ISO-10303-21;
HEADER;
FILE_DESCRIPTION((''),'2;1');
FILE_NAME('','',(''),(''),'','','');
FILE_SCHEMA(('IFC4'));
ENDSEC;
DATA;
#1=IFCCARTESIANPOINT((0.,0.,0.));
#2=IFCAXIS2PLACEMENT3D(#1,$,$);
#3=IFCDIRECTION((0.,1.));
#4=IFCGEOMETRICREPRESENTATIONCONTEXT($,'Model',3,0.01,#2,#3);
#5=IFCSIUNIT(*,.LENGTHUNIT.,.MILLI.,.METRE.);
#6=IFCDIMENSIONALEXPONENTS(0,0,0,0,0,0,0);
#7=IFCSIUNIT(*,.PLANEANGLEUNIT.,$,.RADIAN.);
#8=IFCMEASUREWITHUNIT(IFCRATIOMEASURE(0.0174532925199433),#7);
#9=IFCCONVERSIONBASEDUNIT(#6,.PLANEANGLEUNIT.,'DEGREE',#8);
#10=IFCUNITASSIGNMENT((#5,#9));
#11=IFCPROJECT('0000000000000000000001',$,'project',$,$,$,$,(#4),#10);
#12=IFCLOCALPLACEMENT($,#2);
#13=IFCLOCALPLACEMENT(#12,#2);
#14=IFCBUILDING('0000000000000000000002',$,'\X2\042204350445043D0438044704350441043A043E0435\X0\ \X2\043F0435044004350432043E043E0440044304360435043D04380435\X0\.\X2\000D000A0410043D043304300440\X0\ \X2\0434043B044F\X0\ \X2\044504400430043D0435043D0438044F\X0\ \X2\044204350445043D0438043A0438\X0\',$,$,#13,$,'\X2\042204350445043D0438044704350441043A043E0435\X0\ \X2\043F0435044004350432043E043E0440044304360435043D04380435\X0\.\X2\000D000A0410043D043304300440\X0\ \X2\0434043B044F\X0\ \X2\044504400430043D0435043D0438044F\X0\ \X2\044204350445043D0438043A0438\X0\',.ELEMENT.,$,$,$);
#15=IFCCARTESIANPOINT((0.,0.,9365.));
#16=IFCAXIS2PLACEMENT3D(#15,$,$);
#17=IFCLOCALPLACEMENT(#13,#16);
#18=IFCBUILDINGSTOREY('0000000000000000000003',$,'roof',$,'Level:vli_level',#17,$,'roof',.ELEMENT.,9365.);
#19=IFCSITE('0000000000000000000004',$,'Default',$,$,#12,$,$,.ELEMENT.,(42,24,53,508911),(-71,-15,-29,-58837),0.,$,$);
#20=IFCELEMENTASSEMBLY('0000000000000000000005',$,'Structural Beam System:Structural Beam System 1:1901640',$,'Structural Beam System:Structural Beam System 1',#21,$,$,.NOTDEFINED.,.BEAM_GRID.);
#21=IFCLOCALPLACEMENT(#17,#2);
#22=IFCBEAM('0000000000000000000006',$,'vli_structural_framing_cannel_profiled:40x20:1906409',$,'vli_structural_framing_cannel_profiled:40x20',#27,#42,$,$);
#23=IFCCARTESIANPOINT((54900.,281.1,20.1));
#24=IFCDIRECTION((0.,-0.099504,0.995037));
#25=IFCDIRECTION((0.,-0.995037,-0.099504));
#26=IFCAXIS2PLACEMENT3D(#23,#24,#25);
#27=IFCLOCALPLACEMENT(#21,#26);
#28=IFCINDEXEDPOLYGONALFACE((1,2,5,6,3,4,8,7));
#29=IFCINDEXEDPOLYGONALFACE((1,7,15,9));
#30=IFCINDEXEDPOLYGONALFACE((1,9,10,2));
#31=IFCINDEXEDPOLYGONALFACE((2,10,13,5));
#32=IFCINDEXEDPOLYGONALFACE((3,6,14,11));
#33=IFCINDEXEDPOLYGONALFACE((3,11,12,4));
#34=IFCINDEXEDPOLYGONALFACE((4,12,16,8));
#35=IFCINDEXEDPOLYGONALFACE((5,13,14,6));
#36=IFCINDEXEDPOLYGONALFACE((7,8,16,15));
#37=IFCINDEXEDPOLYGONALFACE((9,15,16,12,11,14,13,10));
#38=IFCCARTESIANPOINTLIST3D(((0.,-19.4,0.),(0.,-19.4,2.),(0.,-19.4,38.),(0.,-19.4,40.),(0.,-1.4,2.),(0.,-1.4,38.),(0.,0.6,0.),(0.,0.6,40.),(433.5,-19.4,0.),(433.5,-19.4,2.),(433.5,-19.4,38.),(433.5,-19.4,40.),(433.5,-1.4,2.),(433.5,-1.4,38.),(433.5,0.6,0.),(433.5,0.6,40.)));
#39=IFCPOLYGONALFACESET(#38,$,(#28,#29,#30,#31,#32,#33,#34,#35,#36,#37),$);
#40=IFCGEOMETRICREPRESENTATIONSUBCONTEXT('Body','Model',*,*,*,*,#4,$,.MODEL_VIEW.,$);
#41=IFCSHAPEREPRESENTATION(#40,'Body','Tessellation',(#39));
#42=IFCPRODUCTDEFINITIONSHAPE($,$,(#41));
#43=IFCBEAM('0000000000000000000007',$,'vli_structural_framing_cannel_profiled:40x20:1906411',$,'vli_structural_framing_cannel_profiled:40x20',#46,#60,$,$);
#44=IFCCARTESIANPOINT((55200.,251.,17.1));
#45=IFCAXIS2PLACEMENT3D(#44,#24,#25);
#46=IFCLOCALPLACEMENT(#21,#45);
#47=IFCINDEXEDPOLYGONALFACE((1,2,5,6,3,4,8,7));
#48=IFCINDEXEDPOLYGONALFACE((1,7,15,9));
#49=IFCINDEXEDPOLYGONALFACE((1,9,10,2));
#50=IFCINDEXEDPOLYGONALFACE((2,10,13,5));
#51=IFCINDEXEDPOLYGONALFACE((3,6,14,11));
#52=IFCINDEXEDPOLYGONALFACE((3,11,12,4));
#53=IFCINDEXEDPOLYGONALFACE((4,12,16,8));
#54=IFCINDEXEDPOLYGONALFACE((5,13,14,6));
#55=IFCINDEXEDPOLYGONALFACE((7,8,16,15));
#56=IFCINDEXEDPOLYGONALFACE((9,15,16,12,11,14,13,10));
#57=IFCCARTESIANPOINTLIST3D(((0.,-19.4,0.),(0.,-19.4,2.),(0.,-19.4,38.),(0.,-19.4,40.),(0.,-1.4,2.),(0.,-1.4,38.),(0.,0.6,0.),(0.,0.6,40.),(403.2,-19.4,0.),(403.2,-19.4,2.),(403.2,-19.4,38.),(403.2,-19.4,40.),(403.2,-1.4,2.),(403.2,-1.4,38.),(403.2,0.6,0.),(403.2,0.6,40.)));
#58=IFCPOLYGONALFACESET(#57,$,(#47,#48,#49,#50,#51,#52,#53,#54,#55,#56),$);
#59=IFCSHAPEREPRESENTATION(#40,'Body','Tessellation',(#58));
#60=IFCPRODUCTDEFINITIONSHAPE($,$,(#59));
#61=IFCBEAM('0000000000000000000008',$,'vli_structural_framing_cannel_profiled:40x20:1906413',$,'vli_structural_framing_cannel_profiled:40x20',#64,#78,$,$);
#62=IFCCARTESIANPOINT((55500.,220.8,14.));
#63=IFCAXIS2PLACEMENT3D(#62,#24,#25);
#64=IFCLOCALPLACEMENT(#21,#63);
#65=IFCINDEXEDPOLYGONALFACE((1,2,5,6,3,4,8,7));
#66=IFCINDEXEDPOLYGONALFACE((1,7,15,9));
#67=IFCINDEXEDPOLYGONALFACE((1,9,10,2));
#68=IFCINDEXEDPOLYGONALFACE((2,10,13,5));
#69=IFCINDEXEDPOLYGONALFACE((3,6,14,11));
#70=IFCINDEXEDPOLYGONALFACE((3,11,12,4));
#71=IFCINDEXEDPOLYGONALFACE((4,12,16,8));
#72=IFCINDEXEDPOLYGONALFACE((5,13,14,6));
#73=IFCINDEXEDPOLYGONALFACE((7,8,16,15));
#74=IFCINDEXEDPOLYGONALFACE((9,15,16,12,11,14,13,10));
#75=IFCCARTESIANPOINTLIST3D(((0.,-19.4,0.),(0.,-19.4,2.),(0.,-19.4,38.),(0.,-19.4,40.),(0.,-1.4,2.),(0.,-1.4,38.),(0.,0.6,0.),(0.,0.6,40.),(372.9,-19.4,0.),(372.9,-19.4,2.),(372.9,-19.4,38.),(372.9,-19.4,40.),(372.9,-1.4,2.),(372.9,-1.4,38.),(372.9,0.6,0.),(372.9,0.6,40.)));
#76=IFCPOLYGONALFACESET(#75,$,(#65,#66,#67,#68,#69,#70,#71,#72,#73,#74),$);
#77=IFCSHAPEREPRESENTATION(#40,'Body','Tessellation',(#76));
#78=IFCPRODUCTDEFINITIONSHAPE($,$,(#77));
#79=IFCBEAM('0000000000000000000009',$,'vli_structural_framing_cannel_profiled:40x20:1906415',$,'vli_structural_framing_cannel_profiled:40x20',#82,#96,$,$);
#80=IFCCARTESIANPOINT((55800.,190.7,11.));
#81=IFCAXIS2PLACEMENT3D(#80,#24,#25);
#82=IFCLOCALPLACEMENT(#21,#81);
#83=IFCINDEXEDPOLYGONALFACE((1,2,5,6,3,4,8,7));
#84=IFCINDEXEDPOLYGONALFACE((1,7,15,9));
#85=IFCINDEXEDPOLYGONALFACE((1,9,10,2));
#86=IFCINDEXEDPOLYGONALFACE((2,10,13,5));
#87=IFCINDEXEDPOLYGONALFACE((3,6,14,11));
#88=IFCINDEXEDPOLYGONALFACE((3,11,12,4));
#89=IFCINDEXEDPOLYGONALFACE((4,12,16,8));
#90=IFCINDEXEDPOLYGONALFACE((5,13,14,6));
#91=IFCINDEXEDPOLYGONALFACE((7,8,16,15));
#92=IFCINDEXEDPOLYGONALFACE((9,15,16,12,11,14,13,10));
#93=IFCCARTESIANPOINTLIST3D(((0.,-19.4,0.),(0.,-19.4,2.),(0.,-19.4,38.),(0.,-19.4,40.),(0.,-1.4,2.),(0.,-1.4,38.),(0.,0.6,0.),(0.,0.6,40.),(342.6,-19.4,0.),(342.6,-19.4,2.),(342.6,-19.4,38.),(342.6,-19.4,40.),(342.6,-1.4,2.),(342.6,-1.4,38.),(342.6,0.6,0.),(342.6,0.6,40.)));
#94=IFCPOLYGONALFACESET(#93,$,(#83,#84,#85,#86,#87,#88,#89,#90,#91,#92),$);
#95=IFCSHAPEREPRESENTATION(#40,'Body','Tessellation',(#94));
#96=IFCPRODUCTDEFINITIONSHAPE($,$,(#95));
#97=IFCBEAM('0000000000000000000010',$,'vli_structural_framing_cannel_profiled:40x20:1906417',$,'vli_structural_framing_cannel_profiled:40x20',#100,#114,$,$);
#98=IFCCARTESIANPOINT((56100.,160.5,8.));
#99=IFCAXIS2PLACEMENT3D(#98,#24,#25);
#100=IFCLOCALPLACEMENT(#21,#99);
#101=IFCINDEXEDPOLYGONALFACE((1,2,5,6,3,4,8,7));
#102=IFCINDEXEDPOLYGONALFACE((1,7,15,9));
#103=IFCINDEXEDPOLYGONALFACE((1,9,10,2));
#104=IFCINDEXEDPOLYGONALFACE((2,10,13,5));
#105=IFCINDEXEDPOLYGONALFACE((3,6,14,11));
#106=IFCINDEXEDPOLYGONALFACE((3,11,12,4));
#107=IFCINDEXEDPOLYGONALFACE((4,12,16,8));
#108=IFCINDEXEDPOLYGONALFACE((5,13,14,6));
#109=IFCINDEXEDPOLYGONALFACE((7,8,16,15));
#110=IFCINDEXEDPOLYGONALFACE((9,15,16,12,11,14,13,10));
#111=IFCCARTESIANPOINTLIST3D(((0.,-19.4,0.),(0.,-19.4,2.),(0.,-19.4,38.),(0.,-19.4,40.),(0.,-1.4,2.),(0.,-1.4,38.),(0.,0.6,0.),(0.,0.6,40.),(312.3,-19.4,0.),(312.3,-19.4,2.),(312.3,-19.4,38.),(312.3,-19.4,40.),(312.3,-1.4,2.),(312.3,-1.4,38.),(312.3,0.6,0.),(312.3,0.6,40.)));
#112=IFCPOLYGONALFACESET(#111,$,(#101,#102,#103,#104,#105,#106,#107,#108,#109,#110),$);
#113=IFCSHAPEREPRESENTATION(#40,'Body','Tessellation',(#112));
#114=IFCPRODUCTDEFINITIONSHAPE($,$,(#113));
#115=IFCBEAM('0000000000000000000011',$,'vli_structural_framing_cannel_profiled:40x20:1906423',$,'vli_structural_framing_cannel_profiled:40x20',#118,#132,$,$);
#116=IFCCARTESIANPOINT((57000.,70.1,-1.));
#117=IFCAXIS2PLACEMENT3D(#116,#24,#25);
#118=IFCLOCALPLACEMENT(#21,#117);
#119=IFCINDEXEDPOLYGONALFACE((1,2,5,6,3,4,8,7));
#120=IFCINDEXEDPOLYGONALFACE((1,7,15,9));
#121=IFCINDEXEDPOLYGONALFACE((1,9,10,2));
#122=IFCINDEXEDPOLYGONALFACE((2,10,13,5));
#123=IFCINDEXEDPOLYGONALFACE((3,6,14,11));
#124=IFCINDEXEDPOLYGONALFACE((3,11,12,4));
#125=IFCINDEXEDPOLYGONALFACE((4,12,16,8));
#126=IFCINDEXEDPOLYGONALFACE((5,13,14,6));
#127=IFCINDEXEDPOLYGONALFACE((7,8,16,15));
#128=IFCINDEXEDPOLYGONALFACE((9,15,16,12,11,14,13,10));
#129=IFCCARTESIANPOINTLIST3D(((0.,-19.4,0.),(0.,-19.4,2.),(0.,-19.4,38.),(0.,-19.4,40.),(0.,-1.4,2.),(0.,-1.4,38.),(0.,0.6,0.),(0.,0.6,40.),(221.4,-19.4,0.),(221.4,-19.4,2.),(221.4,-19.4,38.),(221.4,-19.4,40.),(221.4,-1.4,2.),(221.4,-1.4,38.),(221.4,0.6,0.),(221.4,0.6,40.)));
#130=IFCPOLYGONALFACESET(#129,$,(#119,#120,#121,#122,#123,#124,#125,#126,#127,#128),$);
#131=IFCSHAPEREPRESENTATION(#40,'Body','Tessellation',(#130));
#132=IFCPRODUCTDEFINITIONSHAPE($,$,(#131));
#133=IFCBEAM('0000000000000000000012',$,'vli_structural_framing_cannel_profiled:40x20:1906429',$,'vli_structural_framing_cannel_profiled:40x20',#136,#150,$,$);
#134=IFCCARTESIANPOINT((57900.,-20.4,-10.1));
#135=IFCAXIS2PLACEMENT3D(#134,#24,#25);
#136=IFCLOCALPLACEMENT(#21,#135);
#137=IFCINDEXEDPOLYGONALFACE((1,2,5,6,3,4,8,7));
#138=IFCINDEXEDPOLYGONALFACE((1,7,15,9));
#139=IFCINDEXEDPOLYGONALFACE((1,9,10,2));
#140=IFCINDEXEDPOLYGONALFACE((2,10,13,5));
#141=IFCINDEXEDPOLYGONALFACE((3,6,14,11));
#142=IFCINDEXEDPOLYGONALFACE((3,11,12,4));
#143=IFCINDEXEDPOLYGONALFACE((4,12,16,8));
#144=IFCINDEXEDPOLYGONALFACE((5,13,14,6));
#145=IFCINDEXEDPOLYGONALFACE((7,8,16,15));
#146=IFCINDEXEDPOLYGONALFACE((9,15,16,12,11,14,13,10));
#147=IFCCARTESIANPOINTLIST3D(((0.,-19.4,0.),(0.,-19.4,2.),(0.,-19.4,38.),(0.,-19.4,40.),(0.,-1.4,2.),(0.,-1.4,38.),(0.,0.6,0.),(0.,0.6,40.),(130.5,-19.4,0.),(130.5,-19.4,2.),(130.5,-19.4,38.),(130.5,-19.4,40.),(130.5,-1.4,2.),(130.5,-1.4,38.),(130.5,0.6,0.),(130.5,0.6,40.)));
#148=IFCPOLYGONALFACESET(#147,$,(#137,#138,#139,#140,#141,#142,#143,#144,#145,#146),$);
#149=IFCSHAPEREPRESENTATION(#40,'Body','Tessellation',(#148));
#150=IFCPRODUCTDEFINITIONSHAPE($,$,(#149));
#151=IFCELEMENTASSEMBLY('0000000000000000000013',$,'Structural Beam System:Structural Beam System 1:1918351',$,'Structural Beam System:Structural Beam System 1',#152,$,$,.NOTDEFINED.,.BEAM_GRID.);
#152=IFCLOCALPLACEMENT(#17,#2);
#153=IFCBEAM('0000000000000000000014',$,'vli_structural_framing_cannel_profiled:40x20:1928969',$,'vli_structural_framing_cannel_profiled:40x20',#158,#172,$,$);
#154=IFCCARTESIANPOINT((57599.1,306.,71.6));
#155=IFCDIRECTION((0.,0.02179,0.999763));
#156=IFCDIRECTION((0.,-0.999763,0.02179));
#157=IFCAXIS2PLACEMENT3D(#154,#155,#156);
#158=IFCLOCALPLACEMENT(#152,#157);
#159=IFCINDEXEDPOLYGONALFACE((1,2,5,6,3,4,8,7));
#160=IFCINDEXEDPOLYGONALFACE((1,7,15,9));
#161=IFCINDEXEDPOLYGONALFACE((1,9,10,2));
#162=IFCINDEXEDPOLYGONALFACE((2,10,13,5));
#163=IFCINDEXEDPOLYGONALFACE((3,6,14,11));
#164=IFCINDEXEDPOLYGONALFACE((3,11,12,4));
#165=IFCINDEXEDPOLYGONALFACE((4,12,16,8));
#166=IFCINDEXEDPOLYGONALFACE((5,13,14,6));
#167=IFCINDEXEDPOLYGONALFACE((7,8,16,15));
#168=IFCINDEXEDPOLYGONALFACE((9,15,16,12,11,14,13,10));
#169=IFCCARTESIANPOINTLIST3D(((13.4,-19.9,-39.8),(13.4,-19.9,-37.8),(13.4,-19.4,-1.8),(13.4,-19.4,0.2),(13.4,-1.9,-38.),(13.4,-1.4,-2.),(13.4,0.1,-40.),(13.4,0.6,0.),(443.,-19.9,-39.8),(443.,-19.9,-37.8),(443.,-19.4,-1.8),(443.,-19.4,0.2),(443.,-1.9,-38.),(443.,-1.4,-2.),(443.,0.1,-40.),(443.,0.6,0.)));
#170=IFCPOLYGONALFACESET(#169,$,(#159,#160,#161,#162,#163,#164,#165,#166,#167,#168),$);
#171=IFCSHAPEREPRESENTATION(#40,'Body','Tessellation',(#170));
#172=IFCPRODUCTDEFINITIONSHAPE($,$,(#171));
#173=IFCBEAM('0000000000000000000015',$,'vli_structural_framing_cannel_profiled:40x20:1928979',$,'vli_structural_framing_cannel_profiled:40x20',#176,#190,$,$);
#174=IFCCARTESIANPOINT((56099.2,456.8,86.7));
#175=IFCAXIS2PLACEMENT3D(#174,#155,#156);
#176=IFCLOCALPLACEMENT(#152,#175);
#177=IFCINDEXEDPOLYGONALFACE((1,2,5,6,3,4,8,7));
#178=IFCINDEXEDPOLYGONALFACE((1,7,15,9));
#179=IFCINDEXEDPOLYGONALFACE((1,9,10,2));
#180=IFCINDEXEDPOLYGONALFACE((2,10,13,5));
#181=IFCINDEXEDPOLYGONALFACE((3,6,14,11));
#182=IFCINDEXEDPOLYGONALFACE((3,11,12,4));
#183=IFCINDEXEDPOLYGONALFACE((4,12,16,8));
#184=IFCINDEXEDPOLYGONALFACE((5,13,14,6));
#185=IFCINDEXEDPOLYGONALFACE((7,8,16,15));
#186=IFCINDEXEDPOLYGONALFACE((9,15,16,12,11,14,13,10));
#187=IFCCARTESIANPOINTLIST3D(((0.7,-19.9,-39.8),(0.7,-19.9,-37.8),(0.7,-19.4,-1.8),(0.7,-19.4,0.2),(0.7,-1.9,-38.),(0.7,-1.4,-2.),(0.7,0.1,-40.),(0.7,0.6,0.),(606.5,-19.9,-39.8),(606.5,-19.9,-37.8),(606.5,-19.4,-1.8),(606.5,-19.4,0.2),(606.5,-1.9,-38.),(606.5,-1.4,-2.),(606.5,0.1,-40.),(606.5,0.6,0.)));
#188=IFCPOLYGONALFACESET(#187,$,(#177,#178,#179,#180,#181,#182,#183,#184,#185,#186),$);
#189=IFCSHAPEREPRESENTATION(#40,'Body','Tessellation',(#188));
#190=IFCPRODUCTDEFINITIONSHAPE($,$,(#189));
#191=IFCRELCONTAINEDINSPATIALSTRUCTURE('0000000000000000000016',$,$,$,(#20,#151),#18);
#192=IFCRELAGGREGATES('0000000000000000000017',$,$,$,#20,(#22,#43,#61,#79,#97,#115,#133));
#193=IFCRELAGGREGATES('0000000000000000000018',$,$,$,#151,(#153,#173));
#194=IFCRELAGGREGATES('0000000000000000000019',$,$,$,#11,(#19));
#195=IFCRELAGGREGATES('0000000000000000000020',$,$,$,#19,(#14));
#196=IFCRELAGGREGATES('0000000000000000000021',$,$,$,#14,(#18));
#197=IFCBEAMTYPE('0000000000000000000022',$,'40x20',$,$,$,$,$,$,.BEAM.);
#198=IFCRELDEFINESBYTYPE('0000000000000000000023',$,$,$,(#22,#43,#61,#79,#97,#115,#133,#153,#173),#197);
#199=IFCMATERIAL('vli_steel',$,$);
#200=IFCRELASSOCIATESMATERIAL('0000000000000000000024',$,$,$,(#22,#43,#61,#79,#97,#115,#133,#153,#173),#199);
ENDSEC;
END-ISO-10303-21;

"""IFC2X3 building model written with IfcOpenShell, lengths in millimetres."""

from ifc_helpers import new_model, entity, si_unit, converted_unit, direction, frame, origin, place, context, subcontext, project, spatial, polyline, outline, extrude, material, type_object, element, aggregate, save


model = new_model("IFC2X3")

# Units and contexts
model_context = context("Model", 3, precision=0.01, world=origin(), true_north=direction((0.0, 1.0)))
body_context = subcontext(model_context, "Body", "Model", "MODEL_VIEW")
ifc_project = project(units=[si_unit("LENGTHUNIT", "METRE", prefix="MILLI"), converted_unit("PLANEANGLEUNIT", "DEGREE", entity("IfcRatioMeasure", 0.0174532925199433), si_unit("PLANEANGLEUNIT", "RADIAN"), dimensions=[0, 0, 0, 0, 0, 0, 0])], contexts=[model_context])

# Site, building, storey
site_placement = place(None, origin())
site = spatial("IfcSite", under=ifc_project, at=site_placement, Name="Default", CompositionType="ELEMENT", RefLatitude=(42, 24, 53, 508911), RefLongitude=(-71, -15, -29, -58837), RefElevation=0.0)
building_placement = place(site_placement, origin())
building = spatial("IfcBuilding", under=site, at=building_placement, Name="Техническое перевооружение.\r\nАнгар для хранения техники", LongName="Техническое перевооружение.\r\nАнгар для хранения техники", CompositionType="ELEMENT")
storey_placement = place(building_placement, frame((0.0, 0.0, 9365.0)))
storey = spatial("IfcBuildingStorey", under=building, at=storey_placement, Name="roof", ObjectType="Level:vli_level", LongName="roof", CompositionType="ELEMENT", Elevation=9365.0)

# Element assemblies, beams
assembly_1_placement = place(storey_placement, origin())
assembly_1 = element("IfcElementAssembly", 1, at=assembly_1_placement, inside=storey, Name="Structural Beam System:Structural Beam System 1:1901640", ObjectType="Structural Beam System:Structural Beam System 1", AssemblyPlace="NOTDEFINED", PredefinedType="BEAM_GRID")
ifc_material = material(Name="vli_steel")
beam_type = type_object("IfcBeamType", Name="40x20", PredefinedType="BEAM")
beam_1_placement = place(assembly_1_placement, frame((54900.0, 281.1, 20.1), z_axis=(0.0, -0.099504, 0.995037), x_axis=(0.0, -0.995037, -0.099504)))
beam_1 = element("IfcBeam", 2, at=beam_1_placement, type_object=beam_type, material=ifc_material, Name="vli_structural_framing_cannel_profiled:40x20:1906409", ObjectType="vli_structural_framing_cannel_profiled:40x20", context=body_context, shape_type="SweptSolid", body=[
    extrude(outline(polyline([(-20.0, -9.5), (-18.0, -9.5), (-18.0, 8.5), (18.0, 8.5), (18.0, -9.5), (20.0, -9.5), (20.0, 10.5), (-20.0, 10.5), (-20.0, -9.5)])), frame((0.0, -9.9, 20.0), z_axis=(1.0, 0.0, 0.0), x_axis=(0.0, 0.0, -1.0)), (0.0, 0.0, 1.0), 433.5),
])
beam_2_placement = place(assembly_1_placement, frame((55200.0, 251.0, 17.1), z_axis=(0.0, -0.099504, 0.995037), x_axis=(0.0, -0.995037, -0.099504)))
beam_2 = element("IfcBeam", 3, at=beam_2_placement, type_object=beam_type, material=ifc_material, Name="vli_structural_framing_cannel_profiled:40x20:1906411", ObjectType="vli_structural_framing_cannel_profiled:40x20", context=body_context, shape_type="SweptSolid", body=[
    extrude(outline(polyline([(-20.0, -9.5), (-18.0, -9.5), (-18.0, 8.5), (18.0, 8.5), (18.0, -9.5), (20.0, -9.5), (20.0, 10.5), (-20.0, 10.5), (-20.0, -9.5)])), frame((0.0, -9.9, 20.0), z_axis=(1.0, 0.0, 0.0), x_axis=(0.0, 0.0, -1.0)), (0.0, 0.0, 1.0), 403.2),
])
beam_3_placement = place(assembly_1_placement, frame((55500.0, 220.8, 14.0), z_axis=(0.0, -0.099504, 0.995037), x_axis=(0.0, -0.995037, -0.099504)))
beam_3 = element("IfcBeam", 4, at=beam_3_placement, type_object=beam_type, material=ifc_material, Name="vli_structural_framing_cannel_profiled:40x20:1906413", ObjectType="vli_structural_framing_cannel_profiled:40x20", context=body_context, shape_type="SweptSolid", body=[
    extrude(outline(polyline([(-20.0, -9.5), (-18.0, -9.5), (-18.0, 8.5), (18.0, 8.5), (18.0, -9.5), (20.0, -9.5), (20.0, 10.5), (-20.0, 10.5), (-20.0, -9.5)])), frame((0.0, -9.9, 20.0), z_axis=(1.0, 0.0, 0.0), x_axis=(0.0, 0.0, -1.0)), (0.0, 0.0, 1.0), 372.9),
])
beam_4_placement = place(assembly_1_placement, frame((55800.0, 190.7, 11.0), z_axis=(0.0, -0.099504, 0.995037), x_axis=(0.0, -0.995037, -0.099504)))
beam_4 = element("IfcBeam", 5, at=beam_4_placement, type_object=beam_type, material=ifc_material, Name="vli_structural_framing_cannel_profiled:40x20:1906415", ObjectType="vli_structural_framing_cannel_profiled:40x20", context=body_context, shape_type="SweptSolid", body=[
    extrude(outline(polyline([(-20.0, -9.5), (-18.0, -9.5), (-18.0, 8.5), (18.0, 8.5), (18.0, -9.5), (20.0, -9.5), (20.0, 10.5), (-20.0, 10.5), (-20.0, -9.5)])), frame((0.0, -9.9, 20.0), z_axis=(1.0, 0.0, 0.0), x_axis=(0.0, 0.0, -1.0)), (0.0, 0.0, 1.0), 342.6),
])
beam_5_placement = place(assembly_1_placement, frame((56100.0, 160.5, 8.0), z_axis=(0.0, -0.099504, 0.995037), x_axis=(0.0, -0.995037, -0.099504)))
beam_5 = element("IfcBeam", 6, at=beam_5_placement, type_object=beam_type, material=ifc_material, Name="vli_structural_framing_cannel_profiled:40x20:1906417", ObjectType="vli_structural_framing_cannel_profiled:40x20", context=body_context, shape_type="SweptSolid", body=[
    extrude(outline(polyline([(-20.0, -9.5), (-18.0, -9.5), (-18.0, 8.5), (18.0, 8.5), (18.0, -9.5), (20.0, -9.5), (20.0, 10.5), (-20.0, 10.5), (-20.0, -9.5)])), frame((0.0, -9.9, 20.0), z_axis=(1.0, 0.0, 0.0), x_axis=(0.0, 0.0, -1.0)), (0.0, 0.0, 1.0), 312.3),
])
beam_6_placement = place(assembly_1_placement, frame((57000.0, 70.1, -1.0), z_axis=(0.0, -0.099504, 0.995037), x_axis=(0.0, -0.995037, -0.099504)))
beam_6 = element("IfcBeam", 7, at=beam_6_placement, type_object=beam_type, material=ifc_material, Name="vli_structural_framing_cannel_profiled:40x20:1906423", ObjectType="vli_structural_framing_cannel_profiled:40x20", context=body_context, shape_type="SweptSolid", body=[
    extrude(outline(polyline([(-20.0, -9.5), (-18.0, -9.5), (-18.0, 8.5), (18.0, 8.5), (18.0, -9.5), (20.0, -9.5), (20.0, 10.5), (-20.0, 10.5), (-20.0, -9.5)])), frame((0.0, -9.9, 20.0), z_axis=(1.0, 0.0, 0.0), x_axis=(0.0, 0.0, -1.0)), (0.0, 0.0, 1.0), 221.4),
])
beam_7_placement = place(assembly_1_placement, frame((57900.0, -20.4, -10.1), z_axis=(0.0, -0.099504, 0.995037), x_axis=(0.0, -0.995037, -0.099504)))
beam_7 = element("IfcBeam", 8, at=beam_7_placement, type_object=beam_type, material=ifc_material, Name="vli_structural_framing_cannel_profiled:40x20:1906429", ObjectType="vli_structural_framing_cannel_profiled:40x20", context=body_context, shape_type="SweptSolid", body=[
    extrude(outline(polyline([(-20.0, -9.5), (-18.0, -9.5), (-18.0, 8.5), (18.0, 8.5), (18.0, -9.5), (20.0, -9.5), (20.0, 10.5), (-20.0, 10.5), (-20.0, -9.5)])), frame((0.0, -9.9, 20.0), z_axis=(1.0, 0.0, 0.0), x_axis=(0.0, 0.0, -1.0)), (0.0, 0.0, 1.0), 130.5),
])
aggregate(assembly_1, [beam_1, beam_2, beam_3, beam_4, beam_5, beam_6, beam_7])
assembly_2_placement = place(storey_placement, origin())
assembly_2 = element("IfcElementAssembly", 9, at=assembly_2_placement, inside=storey, Name="Structural Beam System:Structural Beam System 1:1918351", ObjectType="Structural Beam System:Structural Beam System 1", AssemblyPlace="NOTDEFINED", PredefinedType="BEAM_GRID")
beam_8_placement = place(assembly_2_placement, frame((57599.1, 306.0, 71.6), z_axis=(0.0, 0.02179, 0.999763), x_axis=(0.0, -0.999763, 0.02179)))
beam_8 = element("IfcBeam", 10, at=beam_8_placement, type_object=beam_type, material=ifc_material, Name="vli_structural_framing_cannel_profiled:40x20:1928969", ObjectType="vli_structural_framing_cannel_profiled:40x20", context=body_context, shape_type="SweptSolid", body=[
    extrude(outline(polyline([(-10.5, -20.0), (9.5, -20.0), (9.5, -18.0), (-8.5, -18.0), (-8.5, 18.0), (9.5, 18.0), (9.5, 20.0), (-10.5, 20.0), (-10.5, -20.0)])), frame((13.4, -10.1, -19.9), z_axis=(1.0, 0.0, 0.0), x_axis=(0.0, -0.999925, 0.012243)), (0.0, 0.0, 1.0), 429.7),
])
beam_9_placement = place(assembly_2_placement, frame((56099.2, 456.8, 86.7), z_axis=(0.0, 0.02179, 0.999763), x_axis=(0.0, -0.999763, 0.02179)))
beam_9 = element("IfcBeam", 11, at=beam_9_placement, type_object=beam_type, material=ifc_material, Name="vli_structural_framing_cannel_profiled:40x20:1928979", ObjectType="vli_structural_framing_cannel_profiled:40x20", context=body_context, shape_type="SweptSolid", body=[
    extrude(outline(polyline([(-10.5, -20.0), (9.5, -20.0), (9.5, -18.0), (-8.5, -18.0), (-8.5, 18.0), (9.5, 18.0), (9.5, 20.0), (-10.5, 20.0), (-10.5, -20.0)])), frame((0.7, -10.1, -19.9), z_axis=(1.0, 0.0, 0.0), x_axis=(0.0, -0.999925, 0.012243)), (0.0, 0.0, 1.0), 605.8),
])
aggregate(assembly_2, [beam_8, beam_9])

save(model, "model.ifc")
